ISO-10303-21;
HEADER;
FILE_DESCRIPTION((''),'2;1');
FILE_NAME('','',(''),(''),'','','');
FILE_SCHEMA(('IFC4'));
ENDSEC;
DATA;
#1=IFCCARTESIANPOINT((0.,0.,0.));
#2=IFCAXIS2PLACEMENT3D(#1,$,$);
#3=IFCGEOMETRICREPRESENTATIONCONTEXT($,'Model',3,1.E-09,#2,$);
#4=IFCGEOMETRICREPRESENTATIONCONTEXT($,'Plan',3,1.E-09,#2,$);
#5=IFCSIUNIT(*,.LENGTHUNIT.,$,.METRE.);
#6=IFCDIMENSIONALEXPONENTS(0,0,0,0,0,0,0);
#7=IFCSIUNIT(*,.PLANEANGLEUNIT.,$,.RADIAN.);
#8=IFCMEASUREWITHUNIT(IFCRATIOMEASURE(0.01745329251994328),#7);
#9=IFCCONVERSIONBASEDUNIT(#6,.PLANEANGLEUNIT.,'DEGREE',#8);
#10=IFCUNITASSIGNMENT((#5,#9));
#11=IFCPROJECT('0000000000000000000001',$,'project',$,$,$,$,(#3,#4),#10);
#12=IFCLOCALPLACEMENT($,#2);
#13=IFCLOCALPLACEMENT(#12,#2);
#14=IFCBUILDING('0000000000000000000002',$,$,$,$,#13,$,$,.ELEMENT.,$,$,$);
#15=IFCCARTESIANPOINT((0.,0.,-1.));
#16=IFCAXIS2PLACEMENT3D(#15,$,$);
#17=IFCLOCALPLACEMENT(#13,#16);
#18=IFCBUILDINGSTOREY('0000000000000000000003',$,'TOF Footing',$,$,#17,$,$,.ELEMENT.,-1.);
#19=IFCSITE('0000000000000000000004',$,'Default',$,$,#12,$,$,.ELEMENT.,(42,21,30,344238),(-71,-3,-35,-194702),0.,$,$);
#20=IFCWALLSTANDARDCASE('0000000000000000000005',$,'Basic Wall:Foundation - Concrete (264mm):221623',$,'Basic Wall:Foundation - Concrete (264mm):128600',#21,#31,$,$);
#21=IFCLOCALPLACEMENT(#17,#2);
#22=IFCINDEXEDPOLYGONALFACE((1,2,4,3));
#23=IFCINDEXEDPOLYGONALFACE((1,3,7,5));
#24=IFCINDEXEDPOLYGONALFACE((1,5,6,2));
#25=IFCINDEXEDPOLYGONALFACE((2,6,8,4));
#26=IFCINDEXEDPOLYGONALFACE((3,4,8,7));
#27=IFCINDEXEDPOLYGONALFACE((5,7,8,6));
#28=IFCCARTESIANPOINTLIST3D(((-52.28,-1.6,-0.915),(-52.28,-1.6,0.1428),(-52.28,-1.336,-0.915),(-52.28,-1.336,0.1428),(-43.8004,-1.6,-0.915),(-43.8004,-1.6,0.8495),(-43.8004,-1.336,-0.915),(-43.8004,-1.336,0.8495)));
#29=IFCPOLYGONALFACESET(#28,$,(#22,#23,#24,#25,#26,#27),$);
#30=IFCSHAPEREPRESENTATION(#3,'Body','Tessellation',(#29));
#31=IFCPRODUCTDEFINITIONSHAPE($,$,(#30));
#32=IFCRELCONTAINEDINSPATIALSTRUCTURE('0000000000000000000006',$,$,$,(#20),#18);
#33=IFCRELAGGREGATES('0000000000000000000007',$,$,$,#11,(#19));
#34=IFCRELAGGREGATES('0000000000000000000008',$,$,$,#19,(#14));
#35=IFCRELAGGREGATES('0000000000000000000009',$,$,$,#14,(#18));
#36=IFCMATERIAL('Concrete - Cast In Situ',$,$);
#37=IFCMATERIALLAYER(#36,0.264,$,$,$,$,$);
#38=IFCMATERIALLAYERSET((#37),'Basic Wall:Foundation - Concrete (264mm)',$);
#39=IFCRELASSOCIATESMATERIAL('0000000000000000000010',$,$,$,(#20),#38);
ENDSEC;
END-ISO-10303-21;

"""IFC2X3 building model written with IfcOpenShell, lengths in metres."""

from ifc_helpers import new_model, entity, si_unit, converted_unit, frame, frame_2d, origin, place, context, project, spatial, rectangle, extrude, clip, halfspace, material, layer, layer_set, layer_usage, element, save


model = new_model("IFC2X3")

# Units and contexts
model_context = context("Model", 3, precision=1e-09, world=origin())
plan_context = context("Plan", 3, precision=1e-09, world=origin())
ifc_project = project(units=[si_unit("LENGTHUNIT", "METRE"), converted_unit("PLANEANGLEUNIT", "DEGREE", entity("IfcRatioMeasure", 0.01745329251994328), si_unit("PLANEANGLEUNIT", "RADIAN"), dimensions=[0, 0, 0, 0, 0, 0, 0])], contexts=[model_context, plan_context])

# Site, building, storey
site_placement = place(None, origin())
site = spatial("IfcSite", under=ifc_project, at=site_placement, Name="Default", CompositionType="ELEMENT", RefLatitude=(42, 21, 30, 344238), RefLongitude=(-71, -3, -35, -194702), RefElevation=0.0)
building_placement = place(site_placement, origin())
building = spatial("IfcBuilding", under=site, at=building_placement, CompositionType="ELEMENT")
storey_placement = place(building_placement, frame((0.0, 0.0, -1.0)))
storey = spatial("IfcBuildingStorey", under=building, at=storey_placement, Name="TOF Footing", CompositionType="ELEMENT", Elevation=-1.0)

# Shared definitions
ifc_material_1 = material(Name="Concrete - Cast In Situ")
ifc_layer = layer(ifc_material_1, 0.264)
ifc_layer_set = layer_set([ifc_layer], Name="Basic Wall:Foundation - Concrete (264mm)")
ifc_layer_usage = layer_usage(ifc_layer_set, "AXIS2", "NEGATIVE", 0.132)

# Wall
wall_1_placement = place(storey_placement, frame((-43.8004, -1.468, -0.915), z_axis=(0.0, 0.0, 1.0), x_axis=(-1.0, 0.0, 0.0)))
element("IfcWallStandardCase", 1, at=wall_1_placement, inside=storey, material=ifc_layer_usage, Name="Basic Wall:Foundation - Concrete (264mm):221623", ObjectType="Basic Wall:Foundation - Concrete (264mm):128600", context=model_context, shape_type="Clipping", body=[
    clip(extrude(rectangle(XDim=8.4796, YDim=0.264, at=frame_2d((4.2398, 0.0), x_axis=(-1.0, 0.0))), origin(), (0.0, 0.0, 1.0), 1.915), halfspace(frame((0.0, -0.132, 1.7645), z_axis=(0.083045, 0.0, 0.996546), x_axis=(0.0, 1.0, 0.0)), False)),
])

save(model, "model.ifc")
